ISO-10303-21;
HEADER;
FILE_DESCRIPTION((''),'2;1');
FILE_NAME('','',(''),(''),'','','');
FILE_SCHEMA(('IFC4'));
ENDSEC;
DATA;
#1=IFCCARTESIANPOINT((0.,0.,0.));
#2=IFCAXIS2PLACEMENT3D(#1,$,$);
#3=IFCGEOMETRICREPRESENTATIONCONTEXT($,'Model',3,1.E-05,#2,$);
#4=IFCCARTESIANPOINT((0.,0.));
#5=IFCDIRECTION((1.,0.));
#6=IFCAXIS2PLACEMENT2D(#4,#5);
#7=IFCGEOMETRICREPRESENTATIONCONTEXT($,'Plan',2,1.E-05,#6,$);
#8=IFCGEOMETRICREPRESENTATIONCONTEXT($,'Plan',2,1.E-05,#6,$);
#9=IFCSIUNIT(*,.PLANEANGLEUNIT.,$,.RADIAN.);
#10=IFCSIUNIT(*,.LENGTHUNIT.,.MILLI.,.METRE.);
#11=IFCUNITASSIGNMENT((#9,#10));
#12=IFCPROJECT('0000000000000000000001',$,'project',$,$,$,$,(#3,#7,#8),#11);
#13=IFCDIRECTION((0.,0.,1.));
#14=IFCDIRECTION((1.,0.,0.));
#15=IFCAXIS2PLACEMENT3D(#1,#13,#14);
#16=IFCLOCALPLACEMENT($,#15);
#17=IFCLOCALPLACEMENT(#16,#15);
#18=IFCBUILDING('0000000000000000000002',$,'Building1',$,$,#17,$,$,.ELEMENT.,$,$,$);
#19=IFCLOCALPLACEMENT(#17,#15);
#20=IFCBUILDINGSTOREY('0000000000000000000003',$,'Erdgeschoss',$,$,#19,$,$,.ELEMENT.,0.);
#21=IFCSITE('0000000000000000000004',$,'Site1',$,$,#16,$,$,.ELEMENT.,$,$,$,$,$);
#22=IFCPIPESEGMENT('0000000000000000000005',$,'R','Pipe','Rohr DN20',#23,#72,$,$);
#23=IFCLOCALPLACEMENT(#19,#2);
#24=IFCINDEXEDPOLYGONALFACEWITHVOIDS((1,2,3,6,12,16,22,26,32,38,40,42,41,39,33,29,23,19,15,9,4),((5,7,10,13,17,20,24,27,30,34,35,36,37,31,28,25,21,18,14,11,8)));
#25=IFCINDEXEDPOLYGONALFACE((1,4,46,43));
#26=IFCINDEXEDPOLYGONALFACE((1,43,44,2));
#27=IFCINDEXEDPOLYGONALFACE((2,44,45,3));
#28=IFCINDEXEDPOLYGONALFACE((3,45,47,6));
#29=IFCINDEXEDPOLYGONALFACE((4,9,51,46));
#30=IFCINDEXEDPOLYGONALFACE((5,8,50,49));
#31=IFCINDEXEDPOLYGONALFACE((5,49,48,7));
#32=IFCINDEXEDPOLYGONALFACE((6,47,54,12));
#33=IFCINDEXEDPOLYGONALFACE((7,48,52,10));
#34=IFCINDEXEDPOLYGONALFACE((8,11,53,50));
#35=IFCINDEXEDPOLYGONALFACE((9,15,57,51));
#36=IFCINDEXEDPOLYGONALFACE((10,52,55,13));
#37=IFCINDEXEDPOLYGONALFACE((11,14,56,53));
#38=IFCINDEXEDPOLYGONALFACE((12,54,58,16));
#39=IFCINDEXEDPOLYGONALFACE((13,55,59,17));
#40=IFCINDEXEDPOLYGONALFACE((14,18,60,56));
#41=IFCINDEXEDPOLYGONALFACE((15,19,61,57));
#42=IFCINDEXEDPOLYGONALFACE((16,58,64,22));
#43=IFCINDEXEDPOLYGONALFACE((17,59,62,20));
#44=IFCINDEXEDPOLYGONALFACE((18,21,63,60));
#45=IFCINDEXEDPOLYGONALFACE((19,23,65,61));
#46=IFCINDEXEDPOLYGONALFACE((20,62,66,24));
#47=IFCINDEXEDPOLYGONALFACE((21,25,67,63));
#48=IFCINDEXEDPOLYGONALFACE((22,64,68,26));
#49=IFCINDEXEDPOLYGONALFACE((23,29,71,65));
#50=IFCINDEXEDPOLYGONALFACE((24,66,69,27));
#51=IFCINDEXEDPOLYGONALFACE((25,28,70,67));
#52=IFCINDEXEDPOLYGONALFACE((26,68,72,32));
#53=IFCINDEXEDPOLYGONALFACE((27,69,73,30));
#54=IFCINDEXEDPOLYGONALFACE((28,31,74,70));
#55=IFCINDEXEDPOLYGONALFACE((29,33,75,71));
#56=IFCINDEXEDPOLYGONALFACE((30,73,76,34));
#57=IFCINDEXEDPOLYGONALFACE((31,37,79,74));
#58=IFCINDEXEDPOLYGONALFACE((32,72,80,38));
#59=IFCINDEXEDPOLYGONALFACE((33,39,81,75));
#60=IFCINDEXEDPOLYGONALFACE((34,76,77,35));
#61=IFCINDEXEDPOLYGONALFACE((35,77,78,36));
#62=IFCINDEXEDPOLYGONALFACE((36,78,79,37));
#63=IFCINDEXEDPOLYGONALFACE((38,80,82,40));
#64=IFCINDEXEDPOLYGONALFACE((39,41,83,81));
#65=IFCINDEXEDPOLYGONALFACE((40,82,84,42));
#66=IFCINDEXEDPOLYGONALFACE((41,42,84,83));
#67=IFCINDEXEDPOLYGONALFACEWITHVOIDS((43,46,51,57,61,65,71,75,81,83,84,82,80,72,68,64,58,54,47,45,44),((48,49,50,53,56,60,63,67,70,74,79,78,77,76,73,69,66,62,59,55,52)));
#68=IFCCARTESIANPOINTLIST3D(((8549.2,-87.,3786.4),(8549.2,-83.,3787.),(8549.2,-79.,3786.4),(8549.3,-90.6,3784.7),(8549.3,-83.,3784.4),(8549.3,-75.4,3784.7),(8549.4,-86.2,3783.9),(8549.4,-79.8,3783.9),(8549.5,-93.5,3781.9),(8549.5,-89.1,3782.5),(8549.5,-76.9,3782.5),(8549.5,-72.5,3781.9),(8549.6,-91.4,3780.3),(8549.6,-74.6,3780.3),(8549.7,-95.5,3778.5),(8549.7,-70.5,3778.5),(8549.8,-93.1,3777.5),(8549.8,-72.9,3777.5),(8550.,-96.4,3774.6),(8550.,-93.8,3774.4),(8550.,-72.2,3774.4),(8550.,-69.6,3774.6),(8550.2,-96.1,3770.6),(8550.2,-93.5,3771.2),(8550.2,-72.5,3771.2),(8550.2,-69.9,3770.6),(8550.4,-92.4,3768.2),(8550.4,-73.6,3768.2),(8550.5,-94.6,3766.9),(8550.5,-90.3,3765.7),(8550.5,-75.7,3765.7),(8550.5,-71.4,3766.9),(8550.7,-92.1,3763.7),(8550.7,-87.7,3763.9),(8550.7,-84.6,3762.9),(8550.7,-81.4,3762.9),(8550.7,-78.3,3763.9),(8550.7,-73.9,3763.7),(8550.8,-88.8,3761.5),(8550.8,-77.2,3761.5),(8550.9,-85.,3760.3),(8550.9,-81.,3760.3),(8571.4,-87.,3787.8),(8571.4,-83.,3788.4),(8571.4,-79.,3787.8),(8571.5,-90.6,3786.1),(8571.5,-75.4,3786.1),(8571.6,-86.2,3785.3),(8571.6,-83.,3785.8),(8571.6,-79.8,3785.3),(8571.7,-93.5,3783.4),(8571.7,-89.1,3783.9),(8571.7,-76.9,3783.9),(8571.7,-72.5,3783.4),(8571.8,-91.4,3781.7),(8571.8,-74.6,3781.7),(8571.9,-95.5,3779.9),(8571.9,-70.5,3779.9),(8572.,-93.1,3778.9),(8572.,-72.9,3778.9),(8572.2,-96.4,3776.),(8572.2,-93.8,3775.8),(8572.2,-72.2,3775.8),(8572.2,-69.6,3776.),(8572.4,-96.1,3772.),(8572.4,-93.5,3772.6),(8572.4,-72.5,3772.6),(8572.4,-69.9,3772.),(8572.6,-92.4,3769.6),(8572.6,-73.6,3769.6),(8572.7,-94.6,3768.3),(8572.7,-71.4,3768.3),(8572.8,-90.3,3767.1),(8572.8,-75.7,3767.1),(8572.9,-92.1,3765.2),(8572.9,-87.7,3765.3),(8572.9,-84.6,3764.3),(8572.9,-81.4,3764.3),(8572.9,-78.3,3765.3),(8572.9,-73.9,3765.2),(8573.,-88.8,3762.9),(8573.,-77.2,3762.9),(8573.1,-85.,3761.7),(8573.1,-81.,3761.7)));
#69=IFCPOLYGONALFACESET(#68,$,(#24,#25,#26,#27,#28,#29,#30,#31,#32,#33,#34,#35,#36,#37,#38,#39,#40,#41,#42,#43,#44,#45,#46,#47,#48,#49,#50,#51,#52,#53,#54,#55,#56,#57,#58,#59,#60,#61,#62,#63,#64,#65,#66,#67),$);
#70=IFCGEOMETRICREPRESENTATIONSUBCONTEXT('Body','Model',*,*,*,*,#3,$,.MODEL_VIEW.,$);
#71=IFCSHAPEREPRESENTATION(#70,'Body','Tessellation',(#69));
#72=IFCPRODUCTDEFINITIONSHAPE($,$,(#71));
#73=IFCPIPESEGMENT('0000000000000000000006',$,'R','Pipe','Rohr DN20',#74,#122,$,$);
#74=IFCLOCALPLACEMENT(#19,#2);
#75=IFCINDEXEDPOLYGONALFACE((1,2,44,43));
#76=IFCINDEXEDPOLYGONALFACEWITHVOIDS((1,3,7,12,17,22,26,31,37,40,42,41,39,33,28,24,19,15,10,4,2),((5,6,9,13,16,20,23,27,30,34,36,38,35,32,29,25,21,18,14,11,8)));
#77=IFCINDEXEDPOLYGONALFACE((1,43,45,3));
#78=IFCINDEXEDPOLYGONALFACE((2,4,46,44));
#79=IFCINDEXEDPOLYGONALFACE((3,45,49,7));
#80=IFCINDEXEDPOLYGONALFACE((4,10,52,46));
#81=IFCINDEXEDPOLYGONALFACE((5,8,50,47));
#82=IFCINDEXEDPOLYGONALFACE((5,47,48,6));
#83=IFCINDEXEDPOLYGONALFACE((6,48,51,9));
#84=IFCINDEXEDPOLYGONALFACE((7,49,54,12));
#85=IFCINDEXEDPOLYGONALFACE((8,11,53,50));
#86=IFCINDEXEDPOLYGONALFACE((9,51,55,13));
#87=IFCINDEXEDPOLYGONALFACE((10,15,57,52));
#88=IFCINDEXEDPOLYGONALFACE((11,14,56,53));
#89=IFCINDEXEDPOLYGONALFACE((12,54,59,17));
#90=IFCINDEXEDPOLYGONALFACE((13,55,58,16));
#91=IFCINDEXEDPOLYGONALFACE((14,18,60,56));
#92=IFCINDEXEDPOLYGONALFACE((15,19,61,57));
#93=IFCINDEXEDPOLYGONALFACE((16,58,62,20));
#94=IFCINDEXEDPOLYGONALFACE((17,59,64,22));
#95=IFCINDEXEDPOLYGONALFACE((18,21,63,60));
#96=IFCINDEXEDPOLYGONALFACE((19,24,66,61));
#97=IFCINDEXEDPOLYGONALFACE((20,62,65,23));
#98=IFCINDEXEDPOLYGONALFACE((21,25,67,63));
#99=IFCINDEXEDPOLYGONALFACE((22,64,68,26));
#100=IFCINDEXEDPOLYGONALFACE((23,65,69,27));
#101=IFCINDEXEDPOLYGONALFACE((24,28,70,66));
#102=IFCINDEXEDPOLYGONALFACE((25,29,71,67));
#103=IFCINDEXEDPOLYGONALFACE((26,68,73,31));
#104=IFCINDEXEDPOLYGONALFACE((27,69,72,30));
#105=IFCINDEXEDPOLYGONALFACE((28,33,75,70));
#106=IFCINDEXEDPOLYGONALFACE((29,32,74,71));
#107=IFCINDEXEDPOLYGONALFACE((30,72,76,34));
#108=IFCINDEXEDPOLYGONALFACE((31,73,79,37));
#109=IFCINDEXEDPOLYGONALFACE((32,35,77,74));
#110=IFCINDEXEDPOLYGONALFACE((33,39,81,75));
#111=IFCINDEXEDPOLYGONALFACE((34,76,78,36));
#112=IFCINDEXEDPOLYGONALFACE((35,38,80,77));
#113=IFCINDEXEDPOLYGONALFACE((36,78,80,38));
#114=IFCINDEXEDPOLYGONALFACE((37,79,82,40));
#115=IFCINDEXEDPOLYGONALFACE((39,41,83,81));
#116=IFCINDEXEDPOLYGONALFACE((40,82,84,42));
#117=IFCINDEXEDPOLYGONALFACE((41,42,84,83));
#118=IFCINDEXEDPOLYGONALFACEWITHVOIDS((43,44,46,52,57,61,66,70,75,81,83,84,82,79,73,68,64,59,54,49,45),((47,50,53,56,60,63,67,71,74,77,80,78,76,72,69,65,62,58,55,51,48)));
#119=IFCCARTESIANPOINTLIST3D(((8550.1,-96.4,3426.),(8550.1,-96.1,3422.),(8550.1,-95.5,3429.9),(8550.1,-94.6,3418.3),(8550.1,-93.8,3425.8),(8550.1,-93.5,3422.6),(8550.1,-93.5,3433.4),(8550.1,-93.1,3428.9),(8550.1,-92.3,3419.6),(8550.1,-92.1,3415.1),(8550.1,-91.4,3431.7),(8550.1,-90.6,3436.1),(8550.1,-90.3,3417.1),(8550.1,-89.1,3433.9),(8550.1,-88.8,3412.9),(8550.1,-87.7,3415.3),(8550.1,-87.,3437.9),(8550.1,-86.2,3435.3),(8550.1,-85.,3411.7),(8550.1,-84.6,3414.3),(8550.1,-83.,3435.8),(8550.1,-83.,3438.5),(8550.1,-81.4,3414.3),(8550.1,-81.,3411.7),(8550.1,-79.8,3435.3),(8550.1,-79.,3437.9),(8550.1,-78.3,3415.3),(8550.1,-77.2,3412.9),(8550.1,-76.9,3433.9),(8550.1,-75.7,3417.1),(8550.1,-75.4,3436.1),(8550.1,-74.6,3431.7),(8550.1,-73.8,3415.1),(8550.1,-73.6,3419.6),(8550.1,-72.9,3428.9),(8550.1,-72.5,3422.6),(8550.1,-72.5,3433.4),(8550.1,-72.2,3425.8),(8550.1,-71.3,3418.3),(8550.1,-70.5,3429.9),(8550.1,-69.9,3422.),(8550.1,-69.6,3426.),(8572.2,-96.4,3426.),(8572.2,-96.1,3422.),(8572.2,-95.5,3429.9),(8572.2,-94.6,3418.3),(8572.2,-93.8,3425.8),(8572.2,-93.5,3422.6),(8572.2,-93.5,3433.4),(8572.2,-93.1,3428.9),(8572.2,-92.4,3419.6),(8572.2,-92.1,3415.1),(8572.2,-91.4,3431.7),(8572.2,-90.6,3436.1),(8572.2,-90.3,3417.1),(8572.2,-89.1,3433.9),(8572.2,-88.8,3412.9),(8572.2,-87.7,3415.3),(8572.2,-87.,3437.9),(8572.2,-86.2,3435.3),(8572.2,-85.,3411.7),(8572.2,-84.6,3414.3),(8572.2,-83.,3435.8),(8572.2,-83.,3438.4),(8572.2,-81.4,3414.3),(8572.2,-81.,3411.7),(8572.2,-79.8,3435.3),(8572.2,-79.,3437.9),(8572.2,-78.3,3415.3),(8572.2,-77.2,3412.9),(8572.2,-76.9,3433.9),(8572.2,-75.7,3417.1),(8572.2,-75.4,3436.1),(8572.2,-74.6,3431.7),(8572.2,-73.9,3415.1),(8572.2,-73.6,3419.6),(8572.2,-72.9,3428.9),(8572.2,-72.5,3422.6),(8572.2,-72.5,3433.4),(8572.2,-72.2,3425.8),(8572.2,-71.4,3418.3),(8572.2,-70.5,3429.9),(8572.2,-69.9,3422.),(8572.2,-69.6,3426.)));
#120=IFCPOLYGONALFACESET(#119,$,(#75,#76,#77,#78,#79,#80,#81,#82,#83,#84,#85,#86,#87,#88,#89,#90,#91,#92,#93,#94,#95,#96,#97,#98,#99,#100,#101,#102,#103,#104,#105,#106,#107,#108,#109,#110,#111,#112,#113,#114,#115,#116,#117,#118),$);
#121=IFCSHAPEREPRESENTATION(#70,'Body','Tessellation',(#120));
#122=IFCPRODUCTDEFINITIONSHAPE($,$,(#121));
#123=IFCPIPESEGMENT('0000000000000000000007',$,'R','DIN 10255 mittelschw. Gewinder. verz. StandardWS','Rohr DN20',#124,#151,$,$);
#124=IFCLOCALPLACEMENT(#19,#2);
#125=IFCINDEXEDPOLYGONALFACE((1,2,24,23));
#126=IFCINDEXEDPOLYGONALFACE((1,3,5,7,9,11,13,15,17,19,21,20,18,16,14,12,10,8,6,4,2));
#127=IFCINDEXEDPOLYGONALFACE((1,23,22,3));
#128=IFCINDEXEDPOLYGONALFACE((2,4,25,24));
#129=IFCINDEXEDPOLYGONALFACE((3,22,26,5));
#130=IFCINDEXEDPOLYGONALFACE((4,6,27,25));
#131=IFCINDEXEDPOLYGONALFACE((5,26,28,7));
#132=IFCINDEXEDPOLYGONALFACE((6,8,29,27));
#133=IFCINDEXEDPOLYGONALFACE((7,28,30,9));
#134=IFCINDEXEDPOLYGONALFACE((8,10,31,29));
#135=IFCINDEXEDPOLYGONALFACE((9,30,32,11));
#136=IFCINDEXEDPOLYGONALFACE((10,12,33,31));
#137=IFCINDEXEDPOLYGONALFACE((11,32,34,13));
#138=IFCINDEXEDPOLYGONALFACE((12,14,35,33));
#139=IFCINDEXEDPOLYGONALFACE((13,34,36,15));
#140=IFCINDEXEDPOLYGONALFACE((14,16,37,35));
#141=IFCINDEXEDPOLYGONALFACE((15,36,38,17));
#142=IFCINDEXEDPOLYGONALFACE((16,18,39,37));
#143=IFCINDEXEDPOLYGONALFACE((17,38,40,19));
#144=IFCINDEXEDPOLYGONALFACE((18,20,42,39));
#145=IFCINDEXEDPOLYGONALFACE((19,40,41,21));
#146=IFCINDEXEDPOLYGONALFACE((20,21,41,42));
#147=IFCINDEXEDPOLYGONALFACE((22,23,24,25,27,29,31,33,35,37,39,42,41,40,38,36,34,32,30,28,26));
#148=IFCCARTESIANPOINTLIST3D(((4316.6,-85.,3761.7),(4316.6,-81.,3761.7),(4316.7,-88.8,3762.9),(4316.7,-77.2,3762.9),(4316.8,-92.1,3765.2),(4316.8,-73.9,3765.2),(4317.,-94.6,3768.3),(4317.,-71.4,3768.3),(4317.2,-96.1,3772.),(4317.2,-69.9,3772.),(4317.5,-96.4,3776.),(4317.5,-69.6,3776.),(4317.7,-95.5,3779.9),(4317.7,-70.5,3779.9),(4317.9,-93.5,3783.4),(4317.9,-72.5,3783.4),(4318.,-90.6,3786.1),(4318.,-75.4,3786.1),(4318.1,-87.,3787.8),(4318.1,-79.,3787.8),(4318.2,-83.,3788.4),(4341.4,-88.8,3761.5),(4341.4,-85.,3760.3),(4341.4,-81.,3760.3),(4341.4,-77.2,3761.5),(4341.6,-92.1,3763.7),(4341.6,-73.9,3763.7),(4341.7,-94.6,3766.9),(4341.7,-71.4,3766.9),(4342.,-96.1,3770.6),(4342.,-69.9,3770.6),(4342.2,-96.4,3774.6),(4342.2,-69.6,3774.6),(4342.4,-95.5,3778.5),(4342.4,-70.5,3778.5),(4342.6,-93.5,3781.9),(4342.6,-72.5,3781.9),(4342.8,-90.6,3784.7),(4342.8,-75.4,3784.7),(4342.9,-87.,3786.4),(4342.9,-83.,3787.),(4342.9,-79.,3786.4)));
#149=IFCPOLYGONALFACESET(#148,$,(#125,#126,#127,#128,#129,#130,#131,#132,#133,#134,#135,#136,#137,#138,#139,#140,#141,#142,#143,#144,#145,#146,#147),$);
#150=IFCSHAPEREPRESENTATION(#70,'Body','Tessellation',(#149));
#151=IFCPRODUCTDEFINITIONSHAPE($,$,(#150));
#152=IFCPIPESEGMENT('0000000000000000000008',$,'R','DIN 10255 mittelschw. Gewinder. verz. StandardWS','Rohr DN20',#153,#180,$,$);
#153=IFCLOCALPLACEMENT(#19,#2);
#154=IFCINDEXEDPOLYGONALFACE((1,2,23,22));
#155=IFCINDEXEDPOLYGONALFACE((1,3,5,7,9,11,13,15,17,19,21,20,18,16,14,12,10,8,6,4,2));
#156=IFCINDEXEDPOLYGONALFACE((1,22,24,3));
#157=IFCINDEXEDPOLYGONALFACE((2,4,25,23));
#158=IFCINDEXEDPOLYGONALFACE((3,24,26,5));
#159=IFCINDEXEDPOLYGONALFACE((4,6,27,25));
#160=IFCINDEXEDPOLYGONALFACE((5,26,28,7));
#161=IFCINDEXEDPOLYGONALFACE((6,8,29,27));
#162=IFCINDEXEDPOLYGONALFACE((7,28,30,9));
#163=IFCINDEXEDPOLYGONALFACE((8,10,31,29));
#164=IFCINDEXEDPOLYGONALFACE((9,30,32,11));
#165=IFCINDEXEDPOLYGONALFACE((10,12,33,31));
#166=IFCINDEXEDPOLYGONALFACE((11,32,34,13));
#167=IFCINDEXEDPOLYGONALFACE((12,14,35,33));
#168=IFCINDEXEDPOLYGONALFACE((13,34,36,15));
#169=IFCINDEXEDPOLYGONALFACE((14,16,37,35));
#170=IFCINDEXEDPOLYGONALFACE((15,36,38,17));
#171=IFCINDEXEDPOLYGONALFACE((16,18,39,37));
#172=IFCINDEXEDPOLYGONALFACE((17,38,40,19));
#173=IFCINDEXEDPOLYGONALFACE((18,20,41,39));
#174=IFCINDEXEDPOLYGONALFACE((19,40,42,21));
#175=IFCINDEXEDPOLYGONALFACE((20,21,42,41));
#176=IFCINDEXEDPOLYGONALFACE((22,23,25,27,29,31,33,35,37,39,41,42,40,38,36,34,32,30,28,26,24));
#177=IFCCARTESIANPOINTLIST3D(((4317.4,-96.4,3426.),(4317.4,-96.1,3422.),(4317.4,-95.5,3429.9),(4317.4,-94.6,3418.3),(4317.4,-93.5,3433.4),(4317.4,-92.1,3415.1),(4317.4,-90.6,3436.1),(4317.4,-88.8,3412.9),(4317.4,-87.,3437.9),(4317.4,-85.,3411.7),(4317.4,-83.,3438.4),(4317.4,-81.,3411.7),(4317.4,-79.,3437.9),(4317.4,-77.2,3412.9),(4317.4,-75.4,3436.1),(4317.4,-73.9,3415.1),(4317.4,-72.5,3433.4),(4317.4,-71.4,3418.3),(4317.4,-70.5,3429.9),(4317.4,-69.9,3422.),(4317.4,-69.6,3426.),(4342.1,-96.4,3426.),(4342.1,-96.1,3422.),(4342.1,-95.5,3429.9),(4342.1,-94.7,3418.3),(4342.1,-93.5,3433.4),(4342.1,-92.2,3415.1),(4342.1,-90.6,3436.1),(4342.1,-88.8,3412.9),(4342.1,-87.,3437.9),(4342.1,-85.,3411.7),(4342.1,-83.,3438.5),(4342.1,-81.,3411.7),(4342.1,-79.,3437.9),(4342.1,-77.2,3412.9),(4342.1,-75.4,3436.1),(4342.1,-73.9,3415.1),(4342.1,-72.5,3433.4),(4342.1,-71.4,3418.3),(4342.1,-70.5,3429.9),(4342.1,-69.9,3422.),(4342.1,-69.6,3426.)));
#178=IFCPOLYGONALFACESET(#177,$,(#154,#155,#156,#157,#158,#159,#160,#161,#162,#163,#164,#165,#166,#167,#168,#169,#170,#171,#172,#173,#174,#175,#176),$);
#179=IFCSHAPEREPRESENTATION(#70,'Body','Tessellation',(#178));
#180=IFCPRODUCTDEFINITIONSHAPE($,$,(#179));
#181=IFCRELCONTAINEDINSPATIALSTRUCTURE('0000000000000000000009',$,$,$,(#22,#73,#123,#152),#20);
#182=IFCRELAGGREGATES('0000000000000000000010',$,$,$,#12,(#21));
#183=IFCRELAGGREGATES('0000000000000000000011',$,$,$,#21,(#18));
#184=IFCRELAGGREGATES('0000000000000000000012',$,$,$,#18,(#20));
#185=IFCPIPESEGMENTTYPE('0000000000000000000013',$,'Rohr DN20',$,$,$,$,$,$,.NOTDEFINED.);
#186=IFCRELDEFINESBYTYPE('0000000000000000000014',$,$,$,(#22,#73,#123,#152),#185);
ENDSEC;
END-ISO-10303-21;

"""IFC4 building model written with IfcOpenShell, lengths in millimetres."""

from ifc_helpers import new_model, si_unit, frame, origin, origin_with_axes, origin_2d_with_axis, place, context, subcontext, project, spatial, circle, hollow_circle, extrude, type_object, element, save


model = new_model("IFC4")

# Units and contexts
model_context = context("Model", 3, precision=1e-05, world=origin())
plan_context_1 = context("Plan", 2, precision=1e-05, world=origin_2d_with_axis())
plan_context_2 = context("Plan", 2, precision=1e-05, world=origin_2d_with_axis())
body_context = subcontext(model_context, "Body", "Model", "MODEL_VIEW")
ifc_project = project(units=[si_unit("PLANEANGLEUNIT", "RADIAN"), si_unit("LENGTHUNIT", "METRE", prefix="MILLI")], contexts=[model_context, plan_context_1, plan_context_2])

# Site, building, storey
site_placement = place(None, origin_with_axes())
site = spatial("IfcSite", under=ifc_project, at=site_placement, Name="Site1", CompositionType="ELEMENT")
building_placement = place(site_placement, origin_with_axes())
building = spatial("IfcBuilding", under=site, at=building_placement, Name="Building1", CompositionType="ELEMENT")
storey_placement = place(building_placement, origin_with_axes())
storey = spatial("IfcBuildingStorey", under=building, at=storey_placement, Name="Erdgeschoss", CompositionType="ELEMENT", Elevation=0.0)

# Pipe segments
pipe_segment_type_1 = type_object("IfcPipeSegmentType", Name="Rohr DN20", PredefinedType="NOTDEFINED")
pipe_segment_1_placement = place(storey_placement, frame((8561.1, -82.8, 3774.3), z_axis=(0.0, 0.0, 1.0), x_axis=(1.0, 0.0, 0.0)))
element("IfcPipeSegment", 1, at=pipe_segment_1_placement, inside=storey, type_object=pipe_segment_type_1, Name="R", Description="Pipe", ObjectType="Rohr DN20", context=body_context, shape_type="SolidModel", body=[
    extrude(hollow_circle(Radius=13.4, WallThickness=2.6, at=origin_2d_with_axis()), frame((-11.1, -0.1, -0.7), z_axis=(0.99795, 0.0, 0.063994), x_axis=(0.0, 0.0, 1.0)), (0.0, 0.0, 1.0), 22.3),
])
pipe_segment_2_placement = place(storey_placement, frame((8561.2, -82.8, 3425.0), z_axis=(0.0, 0.0, 1.0), x_axis=(1.0, 0.0, 0.0)))
element("IfcPipeSegment", 2, at=pipe_segment_2_placement, inside=storey, type_object=pipe_segment_type_1, Name="R", Description="Pipe", ObjectType="Rohr DN20", context=body_context, shape_type="SolidModel", body=[
    extrude(hollow_circle(Radius=13.4, WallThickness=2.6, at=origin_2d_with_axis()), frame((-11.1, -0.1, 0.0), z_axis=(1.0, -0.000148, -0.000106), x_axis=(0.0, 0.0, 1.0)), (0.0, 0.0, 1.0), 22.2),
])
pipe_segment_3_placement = place(storey_placement, frame((4329.8, -83.2, 3774.3), z_axis=(0.0, 0.0, 1.0), x_axis=(1.0, 0.0, 0.0)))
element("IfcPipeSegment", 3, at=pipe_segment_3_placement, inside=storey, type_object=pipe_segment_type_1, Name="R", Description="DIN 10255 mittelschw. Gewinder. verz. StandardWS", ObjectType="Rohr DN20", context=body_context, shape_type="SolidModel", body=[
    extrude(circle(Radius=13.4, at=origin_2d_with_axis()), frame((12.4, 0.1, -0.7), z_axis=(-0.998345, 0.0, 0.057509), x_axis=(0.0, 0.0, 1.0)), (0.0, 0.0, 1.0), 24.8),
])
pipe_segment_4_placement = place(storey_placement, frame((4329.7, -83.2, 3425.0), z_axis=(0.0, 0.0, 1.0), x_axis=(1.0, 0.0, 0.0)))
element("IfcPipeSegment", 4, at=pipe_segment_4_placement, inside=storey, type_object=pipe_segment_type_1, Name="R", Description="DIN 10255 mittelschw. Gewinder. verz. StandardWS", ObjectType="Rohr DN20", context=body_context, shape_type="SolidModel", body=[
    extrude(circle(Radius=13.4, at=origin_2d_with_axis()), frame((12.3, 0.1, 0.0), z_axis=(-1.0, 0.000133, -0.000096), x_axis=(0.0, 0.0, 1.0)), (0.0, 0.0, 1.0), 24.7),
])

save(model, "model.ifc")
